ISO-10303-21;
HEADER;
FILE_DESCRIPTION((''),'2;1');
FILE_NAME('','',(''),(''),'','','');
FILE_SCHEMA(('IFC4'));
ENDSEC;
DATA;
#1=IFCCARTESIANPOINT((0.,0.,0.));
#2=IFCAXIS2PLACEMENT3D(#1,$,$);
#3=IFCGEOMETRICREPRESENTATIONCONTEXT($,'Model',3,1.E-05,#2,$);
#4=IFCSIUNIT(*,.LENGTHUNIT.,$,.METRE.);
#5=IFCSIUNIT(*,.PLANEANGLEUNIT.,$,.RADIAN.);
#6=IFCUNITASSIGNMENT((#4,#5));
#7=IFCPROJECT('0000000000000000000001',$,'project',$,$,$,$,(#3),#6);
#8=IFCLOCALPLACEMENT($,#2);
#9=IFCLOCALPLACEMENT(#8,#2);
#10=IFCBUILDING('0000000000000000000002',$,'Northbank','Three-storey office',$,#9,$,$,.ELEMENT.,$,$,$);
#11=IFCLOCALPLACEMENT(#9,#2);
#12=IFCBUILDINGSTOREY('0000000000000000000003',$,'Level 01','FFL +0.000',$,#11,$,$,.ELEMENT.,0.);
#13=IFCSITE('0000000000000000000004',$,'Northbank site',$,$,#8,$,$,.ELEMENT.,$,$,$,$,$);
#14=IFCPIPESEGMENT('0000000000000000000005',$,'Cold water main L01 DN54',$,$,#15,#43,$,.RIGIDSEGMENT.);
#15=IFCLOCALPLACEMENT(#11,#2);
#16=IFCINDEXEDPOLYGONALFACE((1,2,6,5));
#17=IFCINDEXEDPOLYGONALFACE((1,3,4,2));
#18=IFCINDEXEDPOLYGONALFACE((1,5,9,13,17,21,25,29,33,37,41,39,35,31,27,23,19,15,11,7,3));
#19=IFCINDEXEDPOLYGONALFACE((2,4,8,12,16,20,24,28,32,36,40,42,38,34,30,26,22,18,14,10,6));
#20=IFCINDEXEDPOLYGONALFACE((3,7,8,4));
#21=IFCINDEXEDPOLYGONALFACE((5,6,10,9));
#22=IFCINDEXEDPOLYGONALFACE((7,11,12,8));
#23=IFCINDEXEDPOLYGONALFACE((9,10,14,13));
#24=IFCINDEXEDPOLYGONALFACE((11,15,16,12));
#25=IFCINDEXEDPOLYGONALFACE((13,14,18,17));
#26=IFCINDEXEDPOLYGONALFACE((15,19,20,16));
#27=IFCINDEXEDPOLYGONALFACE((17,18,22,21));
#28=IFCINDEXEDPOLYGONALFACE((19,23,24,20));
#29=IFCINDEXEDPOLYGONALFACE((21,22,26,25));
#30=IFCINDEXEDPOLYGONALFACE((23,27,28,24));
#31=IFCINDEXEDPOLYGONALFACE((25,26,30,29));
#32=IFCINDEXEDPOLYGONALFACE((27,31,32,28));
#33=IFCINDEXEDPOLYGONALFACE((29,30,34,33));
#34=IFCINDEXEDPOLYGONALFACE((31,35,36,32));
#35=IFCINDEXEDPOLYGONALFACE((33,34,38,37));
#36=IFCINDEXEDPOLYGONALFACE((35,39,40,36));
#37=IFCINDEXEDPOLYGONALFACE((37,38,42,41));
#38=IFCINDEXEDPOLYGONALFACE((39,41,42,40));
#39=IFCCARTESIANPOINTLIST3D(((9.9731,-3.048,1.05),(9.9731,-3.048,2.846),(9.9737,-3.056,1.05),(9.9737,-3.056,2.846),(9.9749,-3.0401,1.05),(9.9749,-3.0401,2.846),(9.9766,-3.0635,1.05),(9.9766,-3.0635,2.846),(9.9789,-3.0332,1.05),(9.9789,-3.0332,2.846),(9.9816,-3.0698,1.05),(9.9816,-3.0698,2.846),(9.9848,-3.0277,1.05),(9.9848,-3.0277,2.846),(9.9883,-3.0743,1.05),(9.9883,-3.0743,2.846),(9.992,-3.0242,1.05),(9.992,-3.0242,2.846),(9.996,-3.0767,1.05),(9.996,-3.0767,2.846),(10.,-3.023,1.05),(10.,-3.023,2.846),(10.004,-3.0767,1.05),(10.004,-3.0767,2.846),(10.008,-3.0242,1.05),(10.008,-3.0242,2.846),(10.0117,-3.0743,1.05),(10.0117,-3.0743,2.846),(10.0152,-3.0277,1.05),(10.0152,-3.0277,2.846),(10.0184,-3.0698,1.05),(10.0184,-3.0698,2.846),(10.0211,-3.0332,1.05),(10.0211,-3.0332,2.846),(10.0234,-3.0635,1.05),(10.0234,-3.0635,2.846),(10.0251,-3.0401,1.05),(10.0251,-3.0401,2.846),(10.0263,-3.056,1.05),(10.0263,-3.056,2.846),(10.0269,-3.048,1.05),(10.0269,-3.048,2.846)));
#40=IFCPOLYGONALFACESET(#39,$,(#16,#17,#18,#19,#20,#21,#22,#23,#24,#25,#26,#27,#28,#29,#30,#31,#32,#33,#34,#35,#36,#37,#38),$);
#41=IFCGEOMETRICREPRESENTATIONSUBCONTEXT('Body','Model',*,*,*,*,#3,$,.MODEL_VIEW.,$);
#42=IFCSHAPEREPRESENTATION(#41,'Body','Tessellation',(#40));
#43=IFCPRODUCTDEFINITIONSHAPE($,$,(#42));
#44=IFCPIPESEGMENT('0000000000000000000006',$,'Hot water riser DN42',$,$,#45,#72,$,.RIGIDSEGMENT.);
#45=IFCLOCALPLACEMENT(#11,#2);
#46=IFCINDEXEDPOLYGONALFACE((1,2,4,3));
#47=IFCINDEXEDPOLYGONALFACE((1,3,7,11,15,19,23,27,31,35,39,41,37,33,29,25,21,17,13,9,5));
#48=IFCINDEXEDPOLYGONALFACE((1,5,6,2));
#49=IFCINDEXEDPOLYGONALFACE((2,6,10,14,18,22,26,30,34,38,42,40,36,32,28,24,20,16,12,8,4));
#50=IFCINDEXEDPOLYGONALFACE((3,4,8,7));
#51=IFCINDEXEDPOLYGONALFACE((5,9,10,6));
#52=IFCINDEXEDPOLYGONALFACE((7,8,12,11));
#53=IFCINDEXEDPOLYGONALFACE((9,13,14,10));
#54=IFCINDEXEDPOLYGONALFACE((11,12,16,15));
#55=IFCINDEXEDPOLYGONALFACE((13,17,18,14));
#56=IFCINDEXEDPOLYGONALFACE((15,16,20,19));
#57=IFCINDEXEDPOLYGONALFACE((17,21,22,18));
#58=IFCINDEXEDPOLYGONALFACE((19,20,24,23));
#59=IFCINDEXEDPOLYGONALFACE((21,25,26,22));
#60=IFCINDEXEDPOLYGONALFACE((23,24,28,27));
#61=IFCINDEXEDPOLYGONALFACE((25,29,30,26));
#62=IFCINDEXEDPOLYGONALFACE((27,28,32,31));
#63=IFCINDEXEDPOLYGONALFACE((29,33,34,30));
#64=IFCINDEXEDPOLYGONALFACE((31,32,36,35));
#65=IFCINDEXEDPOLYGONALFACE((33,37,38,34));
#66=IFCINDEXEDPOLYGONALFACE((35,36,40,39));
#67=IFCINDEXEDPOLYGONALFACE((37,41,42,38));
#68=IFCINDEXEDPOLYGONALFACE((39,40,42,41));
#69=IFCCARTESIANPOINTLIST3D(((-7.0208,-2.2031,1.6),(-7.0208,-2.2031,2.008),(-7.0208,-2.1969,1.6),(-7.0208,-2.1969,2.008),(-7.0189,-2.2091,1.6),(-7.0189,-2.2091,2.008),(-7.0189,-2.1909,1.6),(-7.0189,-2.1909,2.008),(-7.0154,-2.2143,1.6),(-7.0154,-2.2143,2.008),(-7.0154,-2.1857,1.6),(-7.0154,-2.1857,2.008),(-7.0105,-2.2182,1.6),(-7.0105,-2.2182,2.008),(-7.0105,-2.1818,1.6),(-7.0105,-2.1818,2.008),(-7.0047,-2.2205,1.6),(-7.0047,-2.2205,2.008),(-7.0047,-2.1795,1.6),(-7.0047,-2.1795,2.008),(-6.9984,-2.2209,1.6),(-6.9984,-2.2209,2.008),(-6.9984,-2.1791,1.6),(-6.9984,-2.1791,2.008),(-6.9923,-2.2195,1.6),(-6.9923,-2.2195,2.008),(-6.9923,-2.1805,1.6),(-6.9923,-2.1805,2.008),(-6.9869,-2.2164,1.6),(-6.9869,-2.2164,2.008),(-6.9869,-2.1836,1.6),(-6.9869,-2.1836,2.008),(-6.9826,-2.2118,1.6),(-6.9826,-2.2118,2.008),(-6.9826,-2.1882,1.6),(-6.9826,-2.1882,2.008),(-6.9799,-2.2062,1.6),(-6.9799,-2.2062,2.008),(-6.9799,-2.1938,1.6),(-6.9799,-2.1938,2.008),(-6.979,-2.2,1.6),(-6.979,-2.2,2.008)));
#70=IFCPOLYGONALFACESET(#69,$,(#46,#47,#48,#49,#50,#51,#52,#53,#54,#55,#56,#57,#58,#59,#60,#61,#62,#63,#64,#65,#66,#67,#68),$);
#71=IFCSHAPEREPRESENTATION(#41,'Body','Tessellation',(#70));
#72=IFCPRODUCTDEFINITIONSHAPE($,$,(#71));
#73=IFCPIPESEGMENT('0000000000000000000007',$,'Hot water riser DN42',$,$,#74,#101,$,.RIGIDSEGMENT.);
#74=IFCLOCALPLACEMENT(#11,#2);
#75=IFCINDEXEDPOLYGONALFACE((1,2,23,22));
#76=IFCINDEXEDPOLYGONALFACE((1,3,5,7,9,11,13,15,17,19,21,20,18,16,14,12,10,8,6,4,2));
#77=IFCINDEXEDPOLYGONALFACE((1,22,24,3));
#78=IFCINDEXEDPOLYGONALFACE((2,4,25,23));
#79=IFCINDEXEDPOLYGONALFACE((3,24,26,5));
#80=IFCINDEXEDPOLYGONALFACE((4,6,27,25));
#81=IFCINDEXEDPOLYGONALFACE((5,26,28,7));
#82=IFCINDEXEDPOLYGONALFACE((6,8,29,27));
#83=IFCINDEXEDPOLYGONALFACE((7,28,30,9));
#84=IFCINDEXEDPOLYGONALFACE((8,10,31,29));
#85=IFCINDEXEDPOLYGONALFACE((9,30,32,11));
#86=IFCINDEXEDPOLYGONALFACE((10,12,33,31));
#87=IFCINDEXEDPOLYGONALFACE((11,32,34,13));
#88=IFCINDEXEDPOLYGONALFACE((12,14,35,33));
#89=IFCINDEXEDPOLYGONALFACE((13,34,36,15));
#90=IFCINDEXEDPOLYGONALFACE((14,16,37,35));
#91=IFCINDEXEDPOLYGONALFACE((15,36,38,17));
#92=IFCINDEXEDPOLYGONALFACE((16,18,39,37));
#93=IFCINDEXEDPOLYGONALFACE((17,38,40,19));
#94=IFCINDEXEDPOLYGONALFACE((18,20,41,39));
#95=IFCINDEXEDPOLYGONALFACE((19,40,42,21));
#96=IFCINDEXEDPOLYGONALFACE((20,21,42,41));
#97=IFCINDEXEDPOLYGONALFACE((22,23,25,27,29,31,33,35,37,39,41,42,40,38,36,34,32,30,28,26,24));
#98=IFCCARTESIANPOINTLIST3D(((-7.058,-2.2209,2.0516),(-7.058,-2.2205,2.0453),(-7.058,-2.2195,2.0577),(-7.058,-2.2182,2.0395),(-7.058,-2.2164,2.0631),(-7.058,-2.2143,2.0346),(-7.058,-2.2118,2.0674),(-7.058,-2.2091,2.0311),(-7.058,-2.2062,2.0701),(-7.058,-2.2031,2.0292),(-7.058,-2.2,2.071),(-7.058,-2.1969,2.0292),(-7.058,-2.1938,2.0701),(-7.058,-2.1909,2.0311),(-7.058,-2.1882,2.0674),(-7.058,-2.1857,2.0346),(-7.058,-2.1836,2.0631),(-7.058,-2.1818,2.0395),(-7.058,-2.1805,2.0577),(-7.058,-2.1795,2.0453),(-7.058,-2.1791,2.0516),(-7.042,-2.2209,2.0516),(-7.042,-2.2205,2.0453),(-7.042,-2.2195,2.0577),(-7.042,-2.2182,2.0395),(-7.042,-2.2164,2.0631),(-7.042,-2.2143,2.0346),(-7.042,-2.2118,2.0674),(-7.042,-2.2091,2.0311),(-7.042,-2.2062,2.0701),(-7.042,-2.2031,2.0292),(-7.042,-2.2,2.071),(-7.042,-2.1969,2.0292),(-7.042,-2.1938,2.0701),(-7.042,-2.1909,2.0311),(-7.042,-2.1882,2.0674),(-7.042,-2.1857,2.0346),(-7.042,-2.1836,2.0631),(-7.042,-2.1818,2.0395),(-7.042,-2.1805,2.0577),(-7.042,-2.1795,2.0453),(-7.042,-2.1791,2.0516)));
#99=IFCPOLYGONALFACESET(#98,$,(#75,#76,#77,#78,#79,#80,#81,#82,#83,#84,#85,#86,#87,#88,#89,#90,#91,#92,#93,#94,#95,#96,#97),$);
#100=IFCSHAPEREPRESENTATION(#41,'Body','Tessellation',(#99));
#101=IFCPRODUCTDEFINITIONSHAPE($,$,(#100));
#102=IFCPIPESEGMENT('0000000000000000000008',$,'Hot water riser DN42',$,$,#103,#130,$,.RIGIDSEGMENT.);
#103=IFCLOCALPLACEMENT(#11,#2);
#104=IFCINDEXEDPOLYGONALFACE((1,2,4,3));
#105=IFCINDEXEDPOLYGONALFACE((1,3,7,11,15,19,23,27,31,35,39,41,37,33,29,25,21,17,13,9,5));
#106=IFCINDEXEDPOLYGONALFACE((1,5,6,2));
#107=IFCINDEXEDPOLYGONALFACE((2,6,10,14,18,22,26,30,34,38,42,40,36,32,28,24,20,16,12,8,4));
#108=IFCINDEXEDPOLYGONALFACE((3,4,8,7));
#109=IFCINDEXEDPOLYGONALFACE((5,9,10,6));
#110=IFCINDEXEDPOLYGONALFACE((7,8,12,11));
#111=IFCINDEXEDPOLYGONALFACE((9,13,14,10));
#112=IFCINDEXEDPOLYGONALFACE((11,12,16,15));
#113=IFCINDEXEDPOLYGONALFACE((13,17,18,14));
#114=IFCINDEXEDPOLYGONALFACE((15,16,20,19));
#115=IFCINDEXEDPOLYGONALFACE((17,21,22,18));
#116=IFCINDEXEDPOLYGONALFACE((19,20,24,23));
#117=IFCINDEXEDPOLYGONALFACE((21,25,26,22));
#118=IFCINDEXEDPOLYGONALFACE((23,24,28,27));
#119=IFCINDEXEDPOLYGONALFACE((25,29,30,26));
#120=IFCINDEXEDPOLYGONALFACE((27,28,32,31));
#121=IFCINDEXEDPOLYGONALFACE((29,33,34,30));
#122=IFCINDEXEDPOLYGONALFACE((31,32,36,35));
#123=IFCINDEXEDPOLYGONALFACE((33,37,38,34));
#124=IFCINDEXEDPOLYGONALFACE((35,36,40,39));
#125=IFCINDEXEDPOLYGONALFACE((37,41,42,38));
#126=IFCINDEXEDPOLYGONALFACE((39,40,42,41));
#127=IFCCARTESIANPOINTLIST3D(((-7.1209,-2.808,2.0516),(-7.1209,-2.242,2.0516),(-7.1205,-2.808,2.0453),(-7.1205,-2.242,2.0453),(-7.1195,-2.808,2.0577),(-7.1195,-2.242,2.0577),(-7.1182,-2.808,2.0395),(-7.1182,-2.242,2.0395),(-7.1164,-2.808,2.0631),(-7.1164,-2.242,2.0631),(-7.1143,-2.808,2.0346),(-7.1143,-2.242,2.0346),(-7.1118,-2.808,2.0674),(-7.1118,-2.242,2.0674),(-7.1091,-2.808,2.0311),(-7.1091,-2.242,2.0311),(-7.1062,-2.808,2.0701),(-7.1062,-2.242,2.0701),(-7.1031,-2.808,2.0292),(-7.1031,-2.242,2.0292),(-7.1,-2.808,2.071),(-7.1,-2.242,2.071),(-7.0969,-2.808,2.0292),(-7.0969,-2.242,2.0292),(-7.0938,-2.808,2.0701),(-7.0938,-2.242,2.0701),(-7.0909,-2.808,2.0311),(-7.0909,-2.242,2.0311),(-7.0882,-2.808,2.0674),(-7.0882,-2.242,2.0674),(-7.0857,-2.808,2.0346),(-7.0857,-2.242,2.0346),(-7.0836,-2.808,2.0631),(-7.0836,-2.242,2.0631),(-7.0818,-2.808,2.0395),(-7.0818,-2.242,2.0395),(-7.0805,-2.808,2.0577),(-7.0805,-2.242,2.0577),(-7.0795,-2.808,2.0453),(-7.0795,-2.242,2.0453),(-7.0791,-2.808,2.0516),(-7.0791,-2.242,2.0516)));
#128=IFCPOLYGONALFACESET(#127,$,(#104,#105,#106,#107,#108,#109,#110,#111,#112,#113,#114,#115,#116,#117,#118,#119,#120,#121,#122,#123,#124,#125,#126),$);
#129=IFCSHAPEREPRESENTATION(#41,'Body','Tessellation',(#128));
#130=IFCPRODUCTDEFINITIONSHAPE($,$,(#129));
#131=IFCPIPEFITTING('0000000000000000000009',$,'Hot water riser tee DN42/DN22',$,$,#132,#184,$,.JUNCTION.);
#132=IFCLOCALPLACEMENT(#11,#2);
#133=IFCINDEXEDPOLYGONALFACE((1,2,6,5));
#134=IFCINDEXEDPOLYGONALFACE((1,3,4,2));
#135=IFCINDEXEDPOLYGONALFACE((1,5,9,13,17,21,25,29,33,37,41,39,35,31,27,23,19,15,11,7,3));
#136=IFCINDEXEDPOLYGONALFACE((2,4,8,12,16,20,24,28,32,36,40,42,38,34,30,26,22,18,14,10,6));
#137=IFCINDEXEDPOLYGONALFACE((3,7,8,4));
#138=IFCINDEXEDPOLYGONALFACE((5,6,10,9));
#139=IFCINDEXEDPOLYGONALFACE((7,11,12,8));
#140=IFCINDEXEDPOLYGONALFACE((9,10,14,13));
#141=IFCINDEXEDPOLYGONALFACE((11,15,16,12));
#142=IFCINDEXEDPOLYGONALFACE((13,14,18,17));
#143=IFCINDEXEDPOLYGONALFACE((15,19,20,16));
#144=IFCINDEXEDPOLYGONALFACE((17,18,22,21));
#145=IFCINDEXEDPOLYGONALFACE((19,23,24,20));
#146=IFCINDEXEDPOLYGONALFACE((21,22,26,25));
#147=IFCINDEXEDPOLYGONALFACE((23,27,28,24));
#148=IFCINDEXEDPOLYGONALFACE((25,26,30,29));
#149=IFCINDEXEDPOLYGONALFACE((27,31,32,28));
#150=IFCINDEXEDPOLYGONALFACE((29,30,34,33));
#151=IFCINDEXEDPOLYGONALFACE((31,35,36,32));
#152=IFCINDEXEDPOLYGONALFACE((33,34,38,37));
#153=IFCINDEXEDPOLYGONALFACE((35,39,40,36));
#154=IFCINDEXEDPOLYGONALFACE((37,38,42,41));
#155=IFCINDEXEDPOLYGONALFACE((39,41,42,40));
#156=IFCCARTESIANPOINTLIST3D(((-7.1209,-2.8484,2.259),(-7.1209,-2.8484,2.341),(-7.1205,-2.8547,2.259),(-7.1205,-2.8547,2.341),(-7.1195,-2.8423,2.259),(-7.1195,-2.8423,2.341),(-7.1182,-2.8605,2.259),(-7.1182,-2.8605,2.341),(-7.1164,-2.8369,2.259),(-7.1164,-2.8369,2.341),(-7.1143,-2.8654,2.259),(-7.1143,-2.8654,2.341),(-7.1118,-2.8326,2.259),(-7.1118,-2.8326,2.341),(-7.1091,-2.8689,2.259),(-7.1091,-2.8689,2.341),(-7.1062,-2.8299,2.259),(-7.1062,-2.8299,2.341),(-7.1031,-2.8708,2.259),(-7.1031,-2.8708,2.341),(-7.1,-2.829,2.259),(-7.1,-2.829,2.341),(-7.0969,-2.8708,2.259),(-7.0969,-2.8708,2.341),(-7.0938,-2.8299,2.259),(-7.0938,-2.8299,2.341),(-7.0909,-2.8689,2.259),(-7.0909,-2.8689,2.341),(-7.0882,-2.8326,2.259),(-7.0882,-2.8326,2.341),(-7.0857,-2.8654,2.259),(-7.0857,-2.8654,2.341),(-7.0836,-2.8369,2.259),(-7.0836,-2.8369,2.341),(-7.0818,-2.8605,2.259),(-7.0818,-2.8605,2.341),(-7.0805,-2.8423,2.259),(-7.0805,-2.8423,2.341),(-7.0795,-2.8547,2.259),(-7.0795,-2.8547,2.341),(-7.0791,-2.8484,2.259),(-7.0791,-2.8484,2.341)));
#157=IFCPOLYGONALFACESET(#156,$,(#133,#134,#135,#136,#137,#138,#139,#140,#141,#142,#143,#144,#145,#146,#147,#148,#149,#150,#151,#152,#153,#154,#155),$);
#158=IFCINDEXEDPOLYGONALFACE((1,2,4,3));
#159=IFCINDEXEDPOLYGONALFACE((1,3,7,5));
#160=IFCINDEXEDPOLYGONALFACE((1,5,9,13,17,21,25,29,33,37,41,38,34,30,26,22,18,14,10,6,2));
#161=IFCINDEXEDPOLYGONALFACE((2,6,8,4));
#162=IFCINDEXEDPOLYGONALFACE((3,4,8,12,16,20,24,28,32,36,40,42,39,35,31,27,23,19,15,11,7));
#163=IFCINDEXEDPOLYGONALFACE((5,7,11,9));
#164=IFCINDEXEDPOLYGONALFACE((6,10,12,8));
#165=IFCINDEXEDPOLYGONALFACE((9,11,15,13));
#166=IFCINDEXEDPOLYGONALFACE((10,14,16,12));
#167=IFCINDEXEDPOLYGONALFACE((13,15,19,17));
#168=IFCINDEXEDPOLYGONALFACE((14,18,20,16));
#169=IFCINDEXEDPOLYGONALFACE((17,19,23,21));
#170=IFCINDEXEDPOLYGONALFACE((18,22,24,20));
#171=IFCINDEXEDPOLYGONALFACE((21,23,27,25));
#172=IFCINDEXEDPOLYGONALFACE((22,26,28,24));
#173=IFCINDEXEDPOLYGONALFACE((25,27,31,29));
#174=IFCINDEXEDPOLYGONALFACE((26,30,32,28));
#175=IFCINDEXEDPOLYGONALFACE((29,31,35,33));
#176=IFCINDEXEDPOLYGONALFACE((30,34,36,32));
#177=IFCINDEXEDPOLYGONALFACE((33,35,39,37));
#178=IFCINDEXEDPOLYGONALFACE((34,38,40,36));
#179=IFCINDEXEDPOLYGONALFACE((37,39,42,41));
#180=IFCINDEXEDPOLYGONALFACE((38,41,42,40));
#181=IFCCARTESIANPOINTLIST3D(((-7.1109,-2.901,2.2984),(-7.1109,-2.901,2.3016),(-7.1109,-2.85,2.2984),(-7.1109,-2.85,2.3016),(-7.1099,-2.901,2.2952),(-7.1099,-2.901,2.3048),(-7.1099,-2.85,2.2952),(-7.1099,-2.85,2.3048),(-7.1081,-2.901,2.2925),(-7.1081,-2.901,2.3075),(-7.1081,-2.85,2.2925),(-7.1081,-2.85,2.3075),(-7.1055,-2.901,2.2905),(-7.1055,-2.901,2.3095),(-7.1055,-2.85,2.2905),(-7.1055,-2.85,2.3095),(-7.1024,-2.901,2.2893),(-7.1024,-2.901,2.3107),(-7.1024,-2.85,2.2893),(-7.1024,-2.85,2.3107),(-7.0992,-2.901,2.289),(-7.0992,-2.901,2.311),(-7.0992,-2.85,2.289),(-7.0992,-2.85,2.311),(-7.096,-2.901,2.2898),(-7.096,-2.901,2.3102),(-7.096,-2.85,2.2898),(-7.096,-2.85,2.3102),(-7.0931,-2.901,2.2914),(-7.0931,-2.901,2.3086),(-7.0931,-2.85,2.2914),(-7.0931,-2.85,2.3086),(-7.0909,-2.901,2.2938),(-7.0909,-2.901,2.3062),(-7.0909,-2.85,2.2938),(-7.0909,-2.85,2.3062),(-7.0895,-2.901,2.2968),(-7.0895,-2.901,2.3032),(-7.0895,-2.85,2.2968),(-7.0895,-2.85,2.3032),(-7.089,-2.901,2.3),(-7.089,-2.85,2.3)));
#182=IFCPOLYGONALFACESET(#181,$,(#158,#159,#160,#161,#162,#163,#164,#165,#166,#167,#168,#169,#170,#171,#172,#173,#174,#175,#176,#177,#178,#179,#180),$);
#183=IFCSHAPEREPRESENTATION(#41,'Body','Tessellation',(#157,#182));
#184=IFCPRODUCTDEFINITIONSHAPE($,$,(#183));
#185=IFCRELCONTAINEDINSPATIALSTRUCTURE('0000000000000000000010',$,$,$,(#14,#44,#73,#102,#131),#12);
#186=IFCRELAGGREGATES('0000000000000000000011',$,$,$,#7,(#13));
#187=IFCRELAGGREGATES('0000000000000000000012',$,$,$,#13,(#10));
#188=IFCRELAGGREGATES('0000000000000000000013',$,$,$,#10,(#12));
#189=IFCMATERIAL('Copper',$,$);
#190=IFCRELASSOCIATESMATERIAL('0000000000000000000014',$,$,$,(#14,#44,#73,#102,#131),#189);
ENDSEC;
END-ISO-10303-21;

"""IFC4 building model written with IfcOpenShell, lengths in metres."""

from ifc_helpers import new_model, si_unit, frame, origin, place, context, subcontext, project, spatial, circle, extrude, material, element, save


model = new_model("IFC4")

# Units and contexts
model_context = context("Model", 3, precision=1e-05, world=origin())
body_context = subcontext(model_context, "Body", "Model", "MODEL_VIEW")
ifc_project = project(units=[si_unit("LENGTHUNIT", "METRE"), si_unit("PLANEANGLEUNIT", "RADIAN")], contexts=[model_context])

# Site, building, storey
site_placement = place(None, origin())
site = spatial("IfcSite", under=ifc_project, at=site_placement, Name="Northbank site", CompositionType="ELEMENT")
building_placement = place(site_placement, origin())
building = spatial("IfcBuilding", under=site, at=building_placement, Name="Northbank", Description="Three-storey office", CompositionType="ELEMENT")
storey_placement = place(building_placement, origin())
storey = spatial("IfcBuildingStorey", under=building, at=storey_placement, Name="Level 01", Description="FFL +0.000", CompositionType="ELEMENT", Elevation=0.0)

# Shared definitions
ifc_material = material(Name="Copper")

# Pipe segments
pipe_segment_1_placement = place(storey_placement, origin())
element("IfcPipeSegment", 1, at=pipe_segment_1_placement, inside=storey, material=ifc_material, Name="Cold water main L01 DN54", PredefinedType="RIGIDSEGMENT", context=body_context, shape_type="SweptSolid", body=[
    extrude(circle(Radius=0.027), frame((10.0, -3.05, 2.846), z_axis=(0.0, 0.0, -1.0), x_axis=(0.0, 1.0, 0.0)), (0.0, 0.0, 1.0), 1.796),
])
pipe_segment_2_placement = place(storey_placement, origin())
element("IfcPipeSegment", 2, at=pipe_segment_2_placement, inside=storey, material=ifc_material, Name="Hot water riser DN42", PredefinedType="RIGIDSEGMENT", context=body_context, shape_type="SweptSolid", body=[
    extrude(circle(Radius=0.021), frame((-7.0, -2.2, 1.6), z_axis=(0.0, 0.0, 1.0), x_axis=(1.0, 0.0, 0.0)), (0.0, 0.0, 1.0), 0.408),
])
pipe_segment_3_placement = place(storey_placement, origin())
element("IfcPipeSegment", 3, at=pipe_segment_3_placement, inside=storey, material=ifc_material, Name="Hot water riser DN42", PredefinedType="RIGIDSEGMENT", context=body_context, shape_type="SweptSolid", body=[
    extrude(circle(Radius=0.021), frame((-7.042, -2.2, 2.05), z_axis=(-1.0, 0.0, 0.0), x_axis=(0.0, 0.0, 1.0)), (0.0, 0.0, 1.0), 0.016),
])
pipe_segment_4_placement = place(storey_placement, origin())
element("IfcPipeSegment", 4, at=pipe_segment_4_placement, inside=storey, material=ifc_material, Name="Hot water riser DN42", PredefinedType="RIGIDSEGMENT", context=body_context, shape_type="SweptSolid", body=[
    extrude(circle(Radius=0.021), frame((-7.1, -2.242, 2.05), z_axis=(0.0, -1.0, 0.0), x_axis=(0.0, 0.0, 1.0)), (0.0, 0.0, 1.0), 0.566),
])

# Pipe fitting
pipe_fitting_1_placement = place(storey_placement, origin())
element("IfcPipeFitting", 5, at=pipe_fitting_1_placement, inside=storey, material=ifc_material, Name="Hot water riser tee DN42/DN22", PredefinedType="JUNCTION", context=body_context, shape_type="SweptSolid", body=[
    extrude(circle(Radius=0.021), frame((-7.1, -2.85, 2.259), z_axis=(0.0, 0.0, 1.0), x_axis=(0.0, 1.0, 0.0)), (0.0, 0.0, 1.0), 0.082),
    extrude(circle(Radius=0.011), frame((-7.1, -2.85, 2.3), z_axis=(0.0, -1.0, 0.0), x_axis=(1.0, 0.0, 0.0)), (0.0, 0.0, 1.0), 0.051),
])

save(model, "model.ifc")
